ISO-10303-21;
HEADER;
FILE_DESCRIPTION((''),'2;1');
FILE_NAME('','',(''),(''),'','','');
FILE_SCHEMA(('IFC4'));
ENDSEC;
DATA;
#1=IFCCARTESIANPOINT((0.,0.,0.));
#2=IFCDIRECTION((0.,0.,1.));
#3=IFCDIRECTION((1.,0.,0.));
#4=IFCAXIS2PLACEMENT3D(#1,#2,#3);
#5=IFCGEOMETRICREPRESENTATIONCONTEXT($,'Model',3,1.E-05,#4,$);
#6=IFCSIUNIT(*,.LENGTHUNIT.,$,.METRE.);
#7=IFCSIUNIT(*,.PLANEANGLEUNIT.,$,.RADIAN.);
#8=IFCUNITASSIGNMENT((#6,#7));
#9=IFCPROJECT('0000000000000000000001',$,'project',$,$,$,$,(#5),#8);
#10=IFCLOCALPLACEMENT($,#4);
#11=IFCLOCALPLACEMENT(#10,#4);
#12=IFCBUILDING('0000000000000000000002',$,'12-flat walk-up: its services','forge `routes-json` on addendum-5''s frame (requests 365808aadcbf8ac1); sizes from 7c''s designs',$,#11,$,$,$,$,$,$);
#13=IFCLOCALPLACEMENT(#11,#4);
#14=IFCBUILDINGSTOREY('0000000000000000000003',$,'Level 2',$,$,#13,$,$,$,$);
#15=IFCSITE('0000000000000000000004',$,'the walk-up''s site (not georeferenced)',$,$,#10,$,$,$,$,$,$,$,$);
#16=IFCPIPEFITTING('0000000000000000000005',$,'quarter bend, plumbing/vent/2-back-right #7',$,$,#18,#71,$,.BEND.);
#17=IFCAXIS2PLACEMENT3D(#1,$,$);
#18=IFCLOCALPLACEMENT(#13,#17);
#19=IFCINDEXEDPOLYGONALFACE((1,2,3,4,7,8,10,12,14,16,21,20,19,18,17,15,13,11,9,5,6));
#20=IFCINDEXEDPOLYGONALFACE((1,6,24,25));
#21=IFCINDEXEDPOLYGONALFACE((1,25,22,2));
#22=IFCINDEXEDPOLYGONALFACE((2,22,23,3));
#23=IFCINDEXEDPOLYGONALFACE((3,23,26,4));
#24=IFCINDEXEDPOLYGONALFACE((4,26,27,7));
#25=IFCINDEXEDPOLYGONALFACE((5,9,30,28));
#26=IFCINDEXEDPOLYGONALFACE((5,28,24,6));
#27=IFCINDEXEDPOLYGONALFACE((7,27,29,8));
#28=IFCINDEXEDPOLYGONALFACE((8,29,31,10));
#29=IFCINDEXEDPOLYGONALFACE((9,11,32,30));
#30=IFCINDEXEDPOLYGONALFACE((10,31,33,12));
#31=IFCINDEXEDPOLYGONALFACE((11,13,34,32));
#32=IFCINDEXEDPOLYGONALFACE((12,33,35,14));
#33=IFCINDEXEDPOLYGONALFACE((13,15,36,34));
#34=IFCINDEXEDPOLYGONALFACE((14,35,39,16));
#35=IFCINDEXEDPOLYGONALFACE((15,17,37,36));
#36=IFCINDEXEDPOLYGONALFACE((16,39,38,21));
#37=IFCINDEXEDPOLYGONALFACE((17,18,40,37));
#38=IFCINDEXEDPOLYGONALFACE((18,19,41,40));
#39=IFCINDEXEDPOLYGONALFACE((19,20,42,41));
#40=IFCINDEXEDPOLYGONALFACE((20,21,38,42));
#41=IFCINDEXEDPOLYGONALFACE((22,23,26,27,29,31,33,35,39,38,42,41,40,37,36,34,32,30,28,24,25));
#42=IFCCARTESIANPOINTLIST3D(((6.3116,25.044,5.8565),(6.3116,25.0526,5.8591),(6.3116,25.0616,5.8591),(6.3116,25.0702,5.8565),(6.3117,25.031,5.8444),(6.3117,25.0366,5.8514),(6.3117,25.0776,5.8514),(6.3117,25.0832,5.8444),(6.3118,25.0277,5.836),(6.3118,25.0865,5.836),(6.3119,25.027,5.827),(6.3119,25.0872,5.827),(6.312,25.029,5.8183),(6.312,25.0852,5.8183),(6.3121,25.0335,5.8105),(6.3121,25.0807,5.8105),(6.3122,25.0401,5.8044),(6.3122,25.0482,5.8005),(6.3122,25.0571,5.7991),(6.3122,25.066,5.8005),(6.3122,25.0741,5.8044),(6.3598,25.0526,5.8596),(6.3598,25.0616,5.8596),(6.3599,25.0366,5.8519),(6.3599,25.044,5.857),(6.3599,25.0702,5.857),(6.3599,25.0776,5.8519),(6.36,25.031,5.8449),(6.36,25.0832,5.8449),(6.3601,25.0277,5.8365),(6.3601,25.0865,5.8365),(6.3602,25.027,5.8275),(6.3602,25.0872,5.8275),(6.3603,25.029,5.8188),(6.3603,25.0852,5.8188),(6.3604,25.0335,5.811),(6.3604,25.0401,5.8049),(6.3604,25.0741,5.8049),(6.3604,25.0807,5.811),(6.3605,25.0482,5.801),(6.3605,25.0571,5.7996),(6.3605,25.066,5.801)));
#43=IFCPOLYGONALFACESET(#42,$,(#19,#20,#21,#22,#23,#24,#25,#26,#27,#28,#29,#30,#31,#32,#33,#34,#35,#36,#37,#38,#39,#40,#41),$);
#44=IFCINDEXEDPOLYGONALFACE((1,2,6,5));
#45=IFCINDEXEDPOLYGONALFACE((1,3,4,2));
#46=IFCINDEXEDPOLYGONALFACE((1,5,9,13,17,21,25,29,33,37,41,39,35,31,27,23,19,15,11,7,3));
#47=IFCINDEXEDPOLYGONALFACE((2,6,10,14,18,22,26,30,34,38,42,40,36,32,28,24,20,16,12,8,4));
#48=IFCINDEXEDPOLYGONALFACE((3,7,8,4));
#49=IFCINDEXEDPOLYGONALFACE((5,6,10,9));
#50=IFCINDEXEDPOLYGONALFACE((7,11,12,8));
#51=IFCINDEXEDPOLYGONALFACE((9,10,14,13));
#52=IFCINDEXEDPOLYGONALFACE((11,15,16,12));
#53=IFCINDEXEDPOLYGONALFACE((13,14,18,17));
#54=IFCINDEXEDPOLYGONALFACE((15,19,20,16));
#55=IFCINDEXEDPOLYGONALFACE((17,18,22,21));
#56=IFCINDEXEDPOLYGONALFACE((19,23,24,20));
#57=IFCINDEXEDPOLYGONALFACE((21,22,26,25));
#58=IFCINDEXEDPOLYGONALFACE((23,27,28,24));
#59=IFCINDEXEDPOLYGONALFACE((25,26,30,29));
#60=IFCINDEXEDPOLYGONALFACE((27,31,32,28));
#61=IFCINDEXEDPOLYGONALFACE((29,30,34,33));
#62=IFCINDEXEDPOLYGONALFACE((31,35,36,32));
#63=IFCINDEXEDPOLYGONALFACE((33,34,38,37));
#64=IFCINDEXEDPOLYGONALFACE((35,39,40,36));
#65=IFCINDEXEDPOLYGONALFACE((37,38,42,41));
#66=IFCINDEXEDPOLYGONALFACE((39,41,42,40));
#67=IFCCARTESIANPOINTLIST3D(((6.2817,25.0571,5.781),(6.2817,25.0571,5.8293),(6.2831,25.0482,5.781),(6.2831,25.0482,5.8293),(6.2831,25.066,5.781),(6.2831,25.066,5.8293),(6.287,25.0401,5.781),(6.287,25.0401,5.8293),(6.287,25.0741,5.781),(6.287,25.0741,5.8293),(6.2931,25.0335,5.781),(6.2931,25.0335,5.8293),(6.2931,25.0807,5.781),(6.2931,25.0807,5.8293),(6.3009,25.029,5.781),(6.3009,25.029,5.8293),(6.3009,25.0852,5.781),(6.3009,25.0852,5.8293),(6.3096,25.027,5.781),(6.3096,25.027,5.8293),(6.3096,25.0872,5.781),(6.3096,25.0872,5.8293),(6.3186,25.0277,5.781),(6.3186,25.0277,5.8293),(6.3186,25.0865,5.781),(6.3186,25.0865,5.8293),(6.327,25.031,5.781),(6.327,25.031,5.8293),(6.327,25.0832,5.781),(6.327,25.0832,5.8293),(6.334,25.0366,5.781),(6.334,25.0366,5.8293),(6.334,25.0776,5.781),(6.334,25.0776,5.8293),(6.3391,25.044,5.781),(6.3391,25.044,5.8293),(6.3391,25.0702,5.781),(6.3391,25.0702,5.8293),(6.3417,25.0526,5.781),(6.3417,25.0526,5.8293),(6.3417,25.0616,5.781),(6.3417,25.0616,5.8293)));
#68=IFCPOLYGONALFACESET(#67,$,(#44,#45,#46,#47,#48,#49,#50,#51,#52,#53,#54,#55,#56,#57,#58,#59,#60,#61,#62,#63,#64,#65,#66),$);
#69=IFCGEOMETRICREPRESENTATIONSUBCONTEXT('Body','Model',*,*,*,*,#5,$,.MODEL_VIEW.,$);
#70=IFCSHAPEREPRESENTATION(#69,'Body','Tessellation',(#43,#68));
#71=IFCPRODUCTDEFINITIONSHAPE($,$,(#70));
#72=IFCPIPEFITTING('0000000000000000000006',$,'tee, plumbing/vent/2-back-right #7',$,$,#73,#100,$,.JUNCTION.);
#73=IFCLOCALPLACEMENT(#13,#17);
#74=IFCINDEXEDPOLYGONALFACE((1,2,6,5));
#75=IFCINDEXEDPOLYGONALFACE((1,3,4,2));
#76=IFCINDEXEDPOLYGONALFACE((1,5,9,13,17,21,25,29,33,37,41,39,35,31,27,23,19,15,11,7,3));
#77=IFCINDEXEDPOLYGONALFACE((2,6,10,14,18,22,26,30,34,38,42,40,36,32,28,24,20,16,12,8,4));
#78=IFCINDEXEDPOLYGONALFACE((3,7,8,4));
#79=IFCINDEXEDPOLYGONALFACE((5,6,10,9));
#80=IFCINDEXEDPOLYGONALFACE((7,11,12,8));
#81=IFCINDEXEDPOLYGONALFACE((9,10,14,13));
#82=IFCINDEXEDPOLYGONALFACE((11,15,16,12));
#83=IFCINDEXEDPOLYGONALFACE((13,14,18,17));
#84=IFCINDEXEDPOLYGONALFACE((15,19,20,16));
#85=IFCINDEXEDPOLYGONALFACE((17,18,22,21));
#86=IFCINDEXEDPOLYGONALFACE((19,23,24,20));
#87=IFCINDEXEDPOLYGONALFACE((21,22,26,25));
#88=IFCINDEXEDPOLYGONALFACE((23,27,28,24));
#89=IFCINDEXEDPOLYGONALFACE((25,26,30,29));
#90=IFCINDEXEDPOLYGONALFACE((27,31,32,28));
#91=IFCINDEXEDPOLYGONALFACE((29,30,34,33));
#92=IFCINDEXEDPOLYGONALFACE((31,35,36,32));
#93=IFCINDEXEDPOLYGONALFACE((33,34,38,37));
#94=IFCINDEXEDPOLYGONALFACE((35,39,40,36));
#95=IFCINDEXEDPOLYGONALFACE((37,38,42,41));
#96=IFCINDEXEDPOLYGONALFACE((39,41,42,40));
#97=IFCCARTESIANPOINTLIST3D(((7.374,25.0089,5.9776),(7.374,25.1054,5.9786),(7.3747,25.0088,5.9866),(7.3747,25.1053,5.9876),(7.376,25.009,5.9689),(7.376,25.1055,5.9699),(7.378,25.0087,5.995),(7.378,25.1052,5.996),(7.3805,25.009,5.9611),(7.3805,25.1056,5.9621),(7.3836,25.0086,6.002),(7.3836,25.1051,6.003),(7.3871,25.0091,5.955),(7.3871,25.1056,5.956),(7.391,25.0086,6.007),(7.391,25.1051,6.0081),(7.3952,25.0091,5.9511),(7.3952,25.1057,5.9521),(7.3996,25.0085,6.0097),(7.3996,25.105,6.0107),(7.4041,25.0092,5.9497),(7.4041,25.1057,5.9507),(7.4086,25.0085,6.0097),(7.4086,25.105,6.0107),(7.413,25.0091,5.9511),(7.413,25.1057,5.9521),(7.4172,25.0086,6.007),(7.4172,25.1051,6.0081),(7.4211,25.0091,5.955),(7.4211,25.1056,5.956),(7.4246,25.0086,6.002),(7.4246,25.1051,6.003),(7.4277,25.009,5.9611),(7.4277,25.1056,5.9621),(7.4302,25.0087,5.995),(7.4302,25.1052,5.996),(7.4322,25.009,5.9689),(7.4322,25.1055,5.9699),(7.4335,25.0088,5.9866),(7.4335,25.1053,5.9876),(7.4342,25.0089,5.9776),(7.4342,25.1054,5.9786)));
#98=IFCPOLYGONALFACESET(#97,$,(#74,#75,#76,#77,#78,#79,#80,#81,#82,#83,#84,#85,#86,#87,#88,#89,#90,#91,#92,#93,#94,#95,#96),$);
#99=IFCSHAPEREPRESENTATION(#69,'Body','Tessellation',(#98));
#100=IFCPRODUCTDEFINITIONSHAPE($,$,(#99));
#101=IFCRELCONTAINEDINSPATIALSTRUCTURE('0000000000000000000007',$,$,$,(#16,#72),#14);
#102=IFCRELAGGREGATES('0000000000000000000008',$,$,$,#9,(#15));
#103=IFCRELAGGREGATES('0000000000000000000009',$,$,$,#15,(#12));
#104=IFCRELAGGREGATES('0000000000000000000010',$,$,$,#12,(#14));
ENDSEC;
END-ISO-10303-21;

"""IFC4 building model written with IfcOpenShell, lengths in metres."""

from ifc_helpers import new_model, entity, si_unit, frame, origin_with_axes, place, context, subcontext, project, spatial, element, save


model = new_model("IFC4")

# Units and contexts
model_context = context("Model", 3, precision=1e-05, world=origin_with_axes())
body_context = subcontext(model_context, "Body", "Model", "MODEL_VIEW")
ifc_project = project(units=[si_unit("LENGTHUNIT", "METRE"), si_unit("PLANEANGLEUNIT", "RADIAN")], contexts=[model_context])

# Site, building, storey
site_placement = place(None, origin_with_axes())
site = spatial("IfcSite", under=ifc_project, at=site_placement, Name="the walk-up's site (not georeferenced)")
building_placement = place(site_placement, origin_with_axes())
building = spatial("IfcBuilding", under=site, at=building_placement, Name="12-flat walk-up: its services", Description="forge `routes-json` on addendum-5's frame (requests 365808aadcbf8ac1); sizes from 7c's designs")
storey_placement = place(building_placement, origin_with_axes())
storey = spatial("IfcBuildingStorey", under=building, at=storey_placement, Name="Level 2")

# Pipe fittings
pipe_fitting_1_placement = place(storey_placement, frame((6.3602, 25.0571, 5.8298), z_axis=(0.0, 0.0, 1.0), x_axis=(1.0, 0.0, 0.0)))
element("IfcPipeFitting", 1, at=pipe_fitting_1_placement, inside=storey, Name="quarter bend, plumbing/vent/2-back-right #7", PredefinedType="BEND", context=body_context, shape_type="AdvancedSweptSolid", body=[
    entity("IfcSweptDiskSolid", entity("IfcPolyline", [entity("IfcCartesianPoint", [0.0, 0.0, 0.0]), entity("IfcCartesianPoint", [-0.0483, 0.0, -0.0005])]), 0.0302),
    entity("IfcSweptDiskSolid", entity("IfcPolyline", [entity("IfcCartesianPoint", [-0.0483, 0.0, -0.0005]), entity("IfcCartesianPoint", [-0.0483, 0.0, -0.0488])]), 0.0302),
])
pipe_fitting_2_placement = place(storey_placement, frame((7.4041, 25.1054, 5.9809), z_axis=(0.0, 0.0, 1.0), x_axis=(1.0, 0.0, 0.0)))
element("IfcPipeFitting", 2, at=pipe_fitting_2_placement, inside=storey, Name="tee, plumbing/vent/2-back-right #7", PredefinedType="JUNCTION", context=body_context, shape_type="AdvancedSweptSolid", body=[
    entity("IfcSweptDiskSolid", entity("IfcPolyline", [entity("IfcCartesianPoint", [0.0, 0.0, 0.0]), entity("IfcCartesianPoint", [0.0, -0.0965, -0.001])]), 0.0302),
])

save(model, "model.ifc")
